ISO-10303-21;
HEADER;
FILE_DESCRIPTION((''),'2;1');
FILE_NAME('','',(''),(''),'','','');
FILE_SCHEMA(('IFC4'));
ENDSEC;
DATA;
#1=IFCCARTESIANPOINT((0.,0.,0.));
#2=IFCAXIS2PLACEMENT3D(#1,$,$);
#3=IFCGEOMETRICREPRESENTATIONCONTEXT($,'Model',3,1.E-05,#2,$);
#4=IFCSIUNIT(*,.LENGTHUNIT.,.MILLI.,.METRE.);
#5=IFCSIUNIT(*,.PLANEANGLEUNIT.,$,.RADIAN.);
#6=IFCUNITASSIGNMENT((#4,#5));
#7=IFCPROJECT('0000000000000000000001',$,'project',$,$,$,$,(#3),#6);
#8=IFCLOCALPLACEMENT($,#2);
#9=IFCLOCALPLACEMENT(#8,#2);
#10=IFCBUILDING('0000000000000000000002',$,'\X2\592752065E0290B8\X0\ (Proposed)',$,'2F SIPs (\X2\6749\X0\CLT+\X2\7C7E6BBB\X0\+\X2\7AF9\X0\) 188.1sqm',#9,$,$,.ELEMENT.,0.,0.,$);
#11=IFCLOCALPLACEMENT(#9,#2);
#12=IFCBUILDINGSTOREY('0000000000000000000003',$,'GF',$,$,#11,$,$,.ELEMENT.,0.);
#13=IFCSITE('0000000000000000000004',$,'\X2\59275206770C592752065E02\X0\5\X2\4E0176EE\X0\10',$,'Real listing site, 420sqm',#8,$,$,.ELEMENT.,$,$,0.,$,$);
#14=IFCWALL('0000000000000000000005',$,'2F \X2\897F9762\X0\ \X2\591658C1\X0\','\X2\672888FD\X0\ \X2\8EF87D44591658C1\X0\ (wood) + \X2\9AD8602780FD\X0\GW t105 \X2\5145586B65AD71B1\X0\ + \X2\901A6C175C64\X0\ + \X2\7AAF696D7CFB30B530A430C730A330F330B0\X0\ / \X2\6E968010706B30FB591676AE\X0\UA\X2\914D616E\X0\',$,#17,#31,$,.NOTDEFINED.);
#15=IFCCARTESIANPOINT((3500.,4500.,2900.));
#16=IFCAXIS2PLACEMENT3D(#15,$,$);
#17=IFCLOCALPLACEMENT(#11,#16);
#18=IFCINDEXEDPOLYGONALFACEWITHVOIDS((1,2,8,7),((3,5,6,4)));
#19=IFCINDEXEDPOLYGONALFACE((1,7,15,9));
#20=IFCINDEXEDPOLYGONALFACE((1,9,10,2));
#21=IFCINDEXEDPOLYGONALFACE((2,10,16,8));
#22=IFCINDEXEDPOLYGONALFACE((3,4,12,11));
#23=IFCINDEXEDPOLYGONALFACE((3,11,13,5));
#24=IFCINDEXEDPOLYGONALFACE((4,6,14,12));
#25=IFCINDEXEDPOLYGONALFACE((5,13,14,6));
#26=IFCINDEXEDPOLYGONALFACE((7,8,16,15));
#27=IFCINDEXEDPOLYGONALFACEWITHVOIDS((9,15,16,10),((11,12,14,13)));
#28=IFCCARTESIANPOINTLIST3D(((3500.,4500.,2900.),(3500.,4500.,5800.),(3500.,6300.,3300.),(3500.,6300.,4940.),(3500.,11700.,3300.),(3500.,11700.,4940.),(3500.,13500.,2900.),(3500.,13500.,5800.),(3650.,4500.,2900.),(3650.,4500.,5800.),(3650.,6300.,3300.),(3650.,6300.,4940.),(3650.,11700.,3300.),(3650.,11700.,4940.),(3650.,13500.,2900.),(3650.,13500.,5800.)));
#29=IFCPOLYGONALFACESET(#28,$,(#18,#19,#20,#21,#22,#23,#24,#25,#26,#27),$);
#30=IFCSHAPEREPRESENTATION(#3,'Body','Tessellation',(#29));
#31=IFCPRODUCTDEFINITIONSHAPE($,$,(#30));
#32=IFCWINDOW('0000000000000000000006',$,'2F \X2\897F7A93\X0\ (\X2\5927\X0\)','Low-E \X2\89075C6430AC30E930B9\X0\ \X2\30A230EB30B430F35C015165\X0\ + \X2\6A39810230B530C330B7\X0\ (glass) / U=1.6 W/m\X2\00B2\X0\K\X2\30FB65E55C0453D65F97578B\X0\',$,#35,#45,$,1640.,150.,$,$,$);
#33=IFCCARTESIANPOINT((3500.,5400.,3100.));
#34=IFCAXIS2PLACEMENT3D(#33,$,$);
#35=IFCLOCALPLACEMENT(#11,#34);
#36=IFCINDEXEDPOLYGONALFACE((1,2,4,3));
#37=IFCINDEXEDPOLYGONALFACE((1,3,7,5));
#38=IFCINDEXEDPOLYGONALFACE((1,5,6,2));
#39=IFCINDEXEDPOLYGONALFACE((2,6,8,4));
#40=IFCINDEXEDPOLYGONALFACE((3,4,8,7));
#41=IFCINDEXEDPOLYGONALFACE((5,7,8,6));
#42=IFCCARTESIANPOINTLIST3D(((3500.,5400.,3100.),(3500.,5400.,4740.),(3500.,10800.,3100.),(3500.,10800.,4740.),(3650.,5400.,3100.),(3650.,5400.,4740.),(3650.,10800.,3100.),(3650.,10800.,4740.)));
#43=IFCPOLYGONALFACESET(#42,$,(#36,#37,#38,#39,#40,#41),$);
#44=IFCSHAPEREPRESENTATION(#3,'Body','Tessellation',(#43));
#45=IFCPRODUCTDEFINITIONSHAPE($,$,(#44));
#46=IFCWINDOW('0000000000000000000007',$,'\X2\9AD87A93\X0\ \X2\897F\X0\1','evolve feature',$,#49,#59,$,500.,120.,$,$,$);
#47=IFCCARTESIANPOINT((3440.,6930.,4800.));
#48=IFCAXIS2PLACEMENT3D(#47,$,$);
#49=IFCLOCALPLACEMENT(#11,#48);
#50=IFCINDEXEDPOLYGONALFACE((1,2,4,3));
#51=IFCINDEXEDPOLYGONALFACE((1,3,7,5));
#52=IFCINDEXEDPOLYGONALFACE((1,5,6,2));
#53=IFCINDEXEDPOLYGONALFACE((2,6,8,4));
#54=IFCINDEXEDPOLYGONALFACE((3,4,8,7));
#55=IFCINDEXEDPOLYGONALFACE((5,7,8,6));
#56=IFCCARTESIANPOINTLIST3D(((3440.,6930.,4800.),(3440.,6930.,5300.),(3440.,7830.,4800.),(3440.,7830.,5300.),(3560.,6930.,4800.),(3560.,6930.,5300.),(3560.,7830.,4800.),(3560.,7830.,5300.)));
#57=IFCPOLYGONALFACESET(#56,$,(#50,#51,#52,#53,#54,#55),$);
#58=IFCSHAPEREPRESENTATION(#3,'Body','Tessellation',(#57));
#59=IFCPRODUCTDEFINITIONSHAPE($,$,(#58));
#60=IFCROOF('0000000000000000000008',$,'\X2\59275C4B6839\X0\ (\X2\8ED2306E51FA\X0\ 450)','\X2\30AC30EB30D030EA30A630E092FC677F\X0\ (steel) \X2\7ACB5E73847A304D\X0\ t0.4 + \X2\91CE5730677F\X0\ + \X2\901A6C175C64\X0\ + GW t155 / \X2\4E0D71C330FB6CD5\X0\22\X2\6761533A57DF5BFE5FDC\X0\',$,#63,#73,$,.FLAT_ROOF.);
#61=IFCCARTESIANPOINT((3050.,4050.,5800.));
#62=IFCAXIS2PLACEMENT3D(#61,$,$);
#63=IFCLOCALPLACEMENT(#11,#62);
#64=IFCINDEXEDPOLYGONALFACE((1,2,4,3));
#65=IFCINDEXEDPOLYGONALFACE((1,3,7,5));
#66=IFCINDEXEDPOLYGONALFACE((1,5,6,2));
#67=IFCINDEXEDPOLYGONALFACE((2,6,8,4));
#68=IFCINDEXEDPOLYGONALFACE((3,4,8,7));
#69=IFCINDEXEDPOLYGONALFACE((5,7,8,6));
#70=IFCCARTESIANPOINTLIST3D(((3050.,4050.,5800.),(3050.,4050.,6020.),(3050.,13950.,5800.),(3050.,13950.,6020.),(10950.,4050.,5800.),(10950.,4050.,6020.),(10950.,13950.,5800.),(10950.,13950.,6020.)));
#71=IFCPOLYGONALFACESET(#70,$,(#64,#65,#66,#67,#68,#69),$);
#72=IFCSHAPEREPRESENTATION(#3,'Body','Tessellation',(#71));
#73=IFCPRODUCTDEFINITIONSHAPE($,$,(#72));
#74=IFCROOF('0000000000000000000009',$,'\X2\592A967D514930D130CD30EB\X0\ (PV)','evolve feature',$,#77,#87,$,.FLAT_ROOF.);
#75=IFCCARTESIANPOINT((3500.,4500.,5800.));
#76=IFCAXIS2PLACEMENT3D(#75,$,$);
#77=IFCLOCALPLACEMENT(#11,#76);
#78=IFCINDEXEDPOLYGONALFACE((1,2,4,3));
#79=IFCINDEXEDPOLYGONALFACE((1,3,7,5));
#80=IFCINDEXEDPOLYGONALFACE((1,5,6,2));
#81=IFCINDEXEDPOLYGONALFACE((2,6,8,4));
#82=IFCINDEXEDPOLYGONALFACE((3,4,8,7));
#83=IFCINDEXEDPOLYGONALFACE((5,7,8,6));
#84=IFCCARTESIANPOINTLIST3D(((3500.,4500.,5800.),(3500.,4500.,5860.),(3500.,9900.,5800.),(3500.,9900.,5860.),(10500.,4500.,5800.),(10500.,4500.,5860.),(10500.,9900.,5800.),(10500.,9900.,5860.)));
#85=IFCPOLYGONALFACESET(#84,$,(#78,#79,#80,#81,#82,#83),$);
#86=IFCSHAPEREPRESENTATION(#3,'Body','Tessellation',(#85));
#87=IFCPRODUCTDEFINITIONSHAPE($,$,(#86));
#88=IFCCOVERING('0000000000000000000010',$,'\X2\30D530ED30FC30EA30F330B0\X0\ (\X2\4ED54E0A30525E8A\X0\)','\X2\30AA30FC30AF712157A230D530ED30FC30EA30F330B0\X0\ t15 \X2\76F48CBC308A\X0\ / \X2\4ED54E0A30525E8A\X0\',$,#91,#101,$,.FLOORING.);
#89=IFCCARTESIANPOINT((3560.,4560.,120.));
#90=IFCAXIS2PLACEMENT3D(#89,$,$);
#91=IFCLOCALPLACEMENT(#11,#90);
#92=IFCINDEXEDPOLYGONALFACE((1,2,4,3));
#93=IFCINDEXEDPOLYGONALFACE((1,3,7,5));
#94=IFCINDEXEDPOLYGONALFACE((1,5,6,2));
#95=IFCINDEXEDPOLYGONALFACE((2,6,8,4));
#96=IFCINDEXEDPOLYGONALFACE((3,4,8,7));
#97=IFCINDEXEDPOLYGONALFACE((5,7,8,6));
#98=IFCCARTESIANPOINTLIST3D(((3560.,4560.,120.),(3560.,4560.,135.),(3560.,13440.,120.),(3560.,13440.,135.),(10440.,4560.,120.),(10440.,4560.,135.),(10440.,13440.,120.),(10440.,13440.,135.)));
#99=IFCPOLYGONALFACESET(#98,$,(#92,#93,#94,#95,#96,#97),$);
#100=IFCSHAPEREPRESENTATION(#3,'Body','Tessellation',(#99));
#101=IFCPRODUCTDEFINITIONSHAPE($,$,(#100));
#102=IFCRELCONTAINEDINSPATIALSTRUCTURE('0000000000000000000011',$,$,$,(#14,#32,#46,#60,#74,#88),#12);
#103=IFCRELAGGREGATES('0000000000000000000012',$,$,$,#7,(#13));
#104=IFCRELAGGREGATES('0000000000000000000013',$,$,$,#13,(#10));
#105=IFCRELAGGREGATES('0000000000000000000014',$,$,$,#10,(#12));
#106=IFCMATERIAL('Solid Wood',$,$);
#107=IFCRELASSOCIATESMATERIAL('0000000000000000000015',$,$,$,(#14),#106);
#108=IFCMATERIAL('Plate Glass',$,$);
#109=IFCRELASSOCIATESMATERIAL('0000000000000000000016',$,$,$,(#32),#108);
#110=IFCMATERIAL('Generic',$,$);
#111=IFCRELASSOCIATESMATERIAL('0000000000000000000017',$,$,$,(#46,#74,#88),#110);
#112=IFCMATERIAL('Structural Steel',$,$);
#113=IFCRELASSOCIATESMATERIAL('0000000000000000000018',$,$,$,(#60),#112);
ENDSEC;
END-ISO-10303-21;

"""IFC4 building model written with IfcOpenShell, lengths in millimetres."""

from ifc_helpers import new_model, si_unit, frame, frame_2d, origin, place, context, project, spatial, rectangle, extrude, material, element, fill, save


model = new_model("IFC4")

# Units and contexts
model_context = context("Model", 3, precision=1e-05, world=origin())
ifc_project = project(units=[si_unit("LENGTHUNIT", "METRE", prefix="MILLI"), si_unit("PLANEANGLEUNIT", "RADIAN")], contexts=[model_context])

# Site, building, storey
site_placement = place(None, origin())
site = spatial("IfcSite", under=ifc_project, at=site_placement, Name="大分県大分市5丁目10", ObjectType="Real listing site, 420sqm", CompositionType="ELEMENT", RefElevation=0.0)
building_placement = place(site_placement, origin())
building = spatial("IfcBuilding", under=site, at=building_placement, Name="大分市邸 (Proposed)", ObjectType="2F SIPs (杉CLT+籾殻+竹) 188.1sqm", CompositionType="ELEMENT", ElevationOfRefHeight=0.0, ElevationOfTerrain=0.0)
storey_placement = place(building_placement, origin())
storey = spatial("IfcBuildingStorey", under=building, at=storey_placement, Name="GF", CompositionType="ELEMENT", Elevation=0.0)

# Shared definitions
ifc_material_1 = material(Name="Solid Wood")

# Shared definitions
ifc_material_2 = material(Name="Plate Glass")
ifc_material_3 = material(Name="Generic")

# Wall, openings, windows
wall_1_placement = place(storey_placement, frame((3500.0, 4500.0, 2900.0)))
wall_1 = element("IfcWall", 1, at=wall_1_placement, inside=storey, material=ifc_material_1, Name="2F 西面 外壁", Description="木製 軸組外壁 (wood) + 高性能GW t105 充填断熱 + 通気層 + 窯業系サイディング / 準耐火・外皮UA配慮", PredefinedType="NOTDEFINED", context=model_context, shape_type="SweptSolid", body=[
    extrude(rectangle(XDim=150.0, YDim=9000.0, at=frame_2d((75.0, 4500.0))), frame((3500.0, 4500.0, 2900.0)), (0.0, 0.0, 1.0), 2900.0),
])
opening_1_placement = place(storey_placement, frame((3500.0, 5400.0, 3100.0)))
opening_1 = element("IfcOpeningElement", 2, at=opening_1_placement, cuts=wall_1, PredefinedType="NOTDEFINED", context=model_context, shape_type="SweptSolid", body=[
    extrude(rectangle(XDim=150.0, YDim=5400.0, at=frame_2d((75.0, 2700.0))), frame((3500.0, 5400.0, 3100.0)), (0.0, 0.0, 1.0), 1640.0),
])
opening_2_placement = place(storey_placement, frame((3440.0, 6930.0, 4800.0)))
opening_2 = element("IfcOpeningElement", 3, at=opening_2_placement, cuts=wall_1, PredefinedType="NOTDEFINED", context=model_context, shape_type="SweptSolid", body=[
    extrude(rectangle(XDim=120.0, YDim=900.0, at=frame_2d((60.0, 450.0))), frame((3440.0, 6930.0, 4800.0)), (0.0, 0.0, 1.0), 500.0),
])
window_1_placement = place(storey_placement, frame((3500.0, 5400.0, 3100.0)))
window_1 = element("IfcWindow", 4, at=window_1_placement, inside=storey, material=ifc_material_2, Name="2F 西窓 (大)", Description="Low-E 複層ガラス アルゴン封入 + 樹脂サッシ (glass) / U=1.6 W/m²K・日射取得型", OverallHeight=1640.0, OverallWidth=150.0, context=model_context, shape_type="SweptSolid", body=[
    extrude(rectangle(XDim=150.0, YDim=5400.0, at=frame_2d((75.0, 2700.0))), frame((3500.0, 5400.0, 3100.0)), (0.0, 0.0, 1.0), 1640.0),
])
fill(opening_1, window_1)
window_2_placement = place(storey_placement, frame((3440.0, 6930.0, 4800.0)))
window_2 = element("IfcWindow", 5, at=window_2_placement, inside=storey, material=ifc_material_3, Name="高窓 西1", Description="evolve feature", OverallHeight=500.0, OverallWidth=120.0, context=model_context, shape_type="SweptSolid", body=[
    extrude(rectangle(XDim=120.0, YDim=900.0, at=frame_2d((60.0, 450.0))), frame((3440.0, 6930.0, 4800.0)), (0.0, 0.0, 1.0), 500.0),
])
fill(opening_2, window_2)

# Roofs
ifc_material_4 = material(Name="Structural Steel")
roof_1_placement = place(storey_placement, frame((3050.0, 4050.0, 5800.0)))
element("IfcRoof", 6, at=roof_1_placement, inside=storey, material=ifc_material_4, Name="大屋根 (軒の出 450)", Description="ガルバリウム鋼板 (steel) 立平葺き t0.4 + 野地板 + 通気層 + GW t155 / 不燃・法22条区域対応", PredefinedType="FLAT_ROOF", context=model_context, shape_type="SweptSolid", body=[
    extrude(rectangle(XDim=7900.0, YDim=9900.0, at=frame_2d((3950.0, 4950.0))), frame((3050.0, 4050.0, 5800.0)), (0.0, 0.0, 1.0), 220.0),
])
roof_2_placement = place(storey_placement, frame((3500.0, 4500.0, 5800.0)))
element("IfcRoof", 7, at=roof_2_placement, inside=storey, material=ifc_material_3, Name="太陽光パネル (PV)", Description="evolve feature", PredefinedType="FLAT_ROOF", context=model_context, shape_type="SweptSolid", body=[
    extrude(rectangle(XDim=7000.0, YDim=5400.0, at=frame_2d((3500.0, 2700.0))), frame((3500.0, 4500.0, 5800.0)), (0.0, 0.0, 1.0), 60.0),
])

# Covering
covering_placement = place(storey_placement, frame((3560.0, 4560.0, 120.0)))
element("IfcCovering", 8, at=covering_placement, inside=storey, material=ifc_material_3, Name="フローリング (仕上げ床)", Description="オーク無垢フローリング t15 直貼り / 仕上げ床", PredefinedType="FLOORING", context=model_context, shape_type="SweptSolid", body=[
    extrude(rectangle(XDim=6880.0, YDim=8880.0, at=frame_2d((3440.0, 4440.0))), frame((3560.0, 4560.0, 120.0)), (0.0, 0.0, 1.0), 15.0),
])

save(model, "model.ifc")
